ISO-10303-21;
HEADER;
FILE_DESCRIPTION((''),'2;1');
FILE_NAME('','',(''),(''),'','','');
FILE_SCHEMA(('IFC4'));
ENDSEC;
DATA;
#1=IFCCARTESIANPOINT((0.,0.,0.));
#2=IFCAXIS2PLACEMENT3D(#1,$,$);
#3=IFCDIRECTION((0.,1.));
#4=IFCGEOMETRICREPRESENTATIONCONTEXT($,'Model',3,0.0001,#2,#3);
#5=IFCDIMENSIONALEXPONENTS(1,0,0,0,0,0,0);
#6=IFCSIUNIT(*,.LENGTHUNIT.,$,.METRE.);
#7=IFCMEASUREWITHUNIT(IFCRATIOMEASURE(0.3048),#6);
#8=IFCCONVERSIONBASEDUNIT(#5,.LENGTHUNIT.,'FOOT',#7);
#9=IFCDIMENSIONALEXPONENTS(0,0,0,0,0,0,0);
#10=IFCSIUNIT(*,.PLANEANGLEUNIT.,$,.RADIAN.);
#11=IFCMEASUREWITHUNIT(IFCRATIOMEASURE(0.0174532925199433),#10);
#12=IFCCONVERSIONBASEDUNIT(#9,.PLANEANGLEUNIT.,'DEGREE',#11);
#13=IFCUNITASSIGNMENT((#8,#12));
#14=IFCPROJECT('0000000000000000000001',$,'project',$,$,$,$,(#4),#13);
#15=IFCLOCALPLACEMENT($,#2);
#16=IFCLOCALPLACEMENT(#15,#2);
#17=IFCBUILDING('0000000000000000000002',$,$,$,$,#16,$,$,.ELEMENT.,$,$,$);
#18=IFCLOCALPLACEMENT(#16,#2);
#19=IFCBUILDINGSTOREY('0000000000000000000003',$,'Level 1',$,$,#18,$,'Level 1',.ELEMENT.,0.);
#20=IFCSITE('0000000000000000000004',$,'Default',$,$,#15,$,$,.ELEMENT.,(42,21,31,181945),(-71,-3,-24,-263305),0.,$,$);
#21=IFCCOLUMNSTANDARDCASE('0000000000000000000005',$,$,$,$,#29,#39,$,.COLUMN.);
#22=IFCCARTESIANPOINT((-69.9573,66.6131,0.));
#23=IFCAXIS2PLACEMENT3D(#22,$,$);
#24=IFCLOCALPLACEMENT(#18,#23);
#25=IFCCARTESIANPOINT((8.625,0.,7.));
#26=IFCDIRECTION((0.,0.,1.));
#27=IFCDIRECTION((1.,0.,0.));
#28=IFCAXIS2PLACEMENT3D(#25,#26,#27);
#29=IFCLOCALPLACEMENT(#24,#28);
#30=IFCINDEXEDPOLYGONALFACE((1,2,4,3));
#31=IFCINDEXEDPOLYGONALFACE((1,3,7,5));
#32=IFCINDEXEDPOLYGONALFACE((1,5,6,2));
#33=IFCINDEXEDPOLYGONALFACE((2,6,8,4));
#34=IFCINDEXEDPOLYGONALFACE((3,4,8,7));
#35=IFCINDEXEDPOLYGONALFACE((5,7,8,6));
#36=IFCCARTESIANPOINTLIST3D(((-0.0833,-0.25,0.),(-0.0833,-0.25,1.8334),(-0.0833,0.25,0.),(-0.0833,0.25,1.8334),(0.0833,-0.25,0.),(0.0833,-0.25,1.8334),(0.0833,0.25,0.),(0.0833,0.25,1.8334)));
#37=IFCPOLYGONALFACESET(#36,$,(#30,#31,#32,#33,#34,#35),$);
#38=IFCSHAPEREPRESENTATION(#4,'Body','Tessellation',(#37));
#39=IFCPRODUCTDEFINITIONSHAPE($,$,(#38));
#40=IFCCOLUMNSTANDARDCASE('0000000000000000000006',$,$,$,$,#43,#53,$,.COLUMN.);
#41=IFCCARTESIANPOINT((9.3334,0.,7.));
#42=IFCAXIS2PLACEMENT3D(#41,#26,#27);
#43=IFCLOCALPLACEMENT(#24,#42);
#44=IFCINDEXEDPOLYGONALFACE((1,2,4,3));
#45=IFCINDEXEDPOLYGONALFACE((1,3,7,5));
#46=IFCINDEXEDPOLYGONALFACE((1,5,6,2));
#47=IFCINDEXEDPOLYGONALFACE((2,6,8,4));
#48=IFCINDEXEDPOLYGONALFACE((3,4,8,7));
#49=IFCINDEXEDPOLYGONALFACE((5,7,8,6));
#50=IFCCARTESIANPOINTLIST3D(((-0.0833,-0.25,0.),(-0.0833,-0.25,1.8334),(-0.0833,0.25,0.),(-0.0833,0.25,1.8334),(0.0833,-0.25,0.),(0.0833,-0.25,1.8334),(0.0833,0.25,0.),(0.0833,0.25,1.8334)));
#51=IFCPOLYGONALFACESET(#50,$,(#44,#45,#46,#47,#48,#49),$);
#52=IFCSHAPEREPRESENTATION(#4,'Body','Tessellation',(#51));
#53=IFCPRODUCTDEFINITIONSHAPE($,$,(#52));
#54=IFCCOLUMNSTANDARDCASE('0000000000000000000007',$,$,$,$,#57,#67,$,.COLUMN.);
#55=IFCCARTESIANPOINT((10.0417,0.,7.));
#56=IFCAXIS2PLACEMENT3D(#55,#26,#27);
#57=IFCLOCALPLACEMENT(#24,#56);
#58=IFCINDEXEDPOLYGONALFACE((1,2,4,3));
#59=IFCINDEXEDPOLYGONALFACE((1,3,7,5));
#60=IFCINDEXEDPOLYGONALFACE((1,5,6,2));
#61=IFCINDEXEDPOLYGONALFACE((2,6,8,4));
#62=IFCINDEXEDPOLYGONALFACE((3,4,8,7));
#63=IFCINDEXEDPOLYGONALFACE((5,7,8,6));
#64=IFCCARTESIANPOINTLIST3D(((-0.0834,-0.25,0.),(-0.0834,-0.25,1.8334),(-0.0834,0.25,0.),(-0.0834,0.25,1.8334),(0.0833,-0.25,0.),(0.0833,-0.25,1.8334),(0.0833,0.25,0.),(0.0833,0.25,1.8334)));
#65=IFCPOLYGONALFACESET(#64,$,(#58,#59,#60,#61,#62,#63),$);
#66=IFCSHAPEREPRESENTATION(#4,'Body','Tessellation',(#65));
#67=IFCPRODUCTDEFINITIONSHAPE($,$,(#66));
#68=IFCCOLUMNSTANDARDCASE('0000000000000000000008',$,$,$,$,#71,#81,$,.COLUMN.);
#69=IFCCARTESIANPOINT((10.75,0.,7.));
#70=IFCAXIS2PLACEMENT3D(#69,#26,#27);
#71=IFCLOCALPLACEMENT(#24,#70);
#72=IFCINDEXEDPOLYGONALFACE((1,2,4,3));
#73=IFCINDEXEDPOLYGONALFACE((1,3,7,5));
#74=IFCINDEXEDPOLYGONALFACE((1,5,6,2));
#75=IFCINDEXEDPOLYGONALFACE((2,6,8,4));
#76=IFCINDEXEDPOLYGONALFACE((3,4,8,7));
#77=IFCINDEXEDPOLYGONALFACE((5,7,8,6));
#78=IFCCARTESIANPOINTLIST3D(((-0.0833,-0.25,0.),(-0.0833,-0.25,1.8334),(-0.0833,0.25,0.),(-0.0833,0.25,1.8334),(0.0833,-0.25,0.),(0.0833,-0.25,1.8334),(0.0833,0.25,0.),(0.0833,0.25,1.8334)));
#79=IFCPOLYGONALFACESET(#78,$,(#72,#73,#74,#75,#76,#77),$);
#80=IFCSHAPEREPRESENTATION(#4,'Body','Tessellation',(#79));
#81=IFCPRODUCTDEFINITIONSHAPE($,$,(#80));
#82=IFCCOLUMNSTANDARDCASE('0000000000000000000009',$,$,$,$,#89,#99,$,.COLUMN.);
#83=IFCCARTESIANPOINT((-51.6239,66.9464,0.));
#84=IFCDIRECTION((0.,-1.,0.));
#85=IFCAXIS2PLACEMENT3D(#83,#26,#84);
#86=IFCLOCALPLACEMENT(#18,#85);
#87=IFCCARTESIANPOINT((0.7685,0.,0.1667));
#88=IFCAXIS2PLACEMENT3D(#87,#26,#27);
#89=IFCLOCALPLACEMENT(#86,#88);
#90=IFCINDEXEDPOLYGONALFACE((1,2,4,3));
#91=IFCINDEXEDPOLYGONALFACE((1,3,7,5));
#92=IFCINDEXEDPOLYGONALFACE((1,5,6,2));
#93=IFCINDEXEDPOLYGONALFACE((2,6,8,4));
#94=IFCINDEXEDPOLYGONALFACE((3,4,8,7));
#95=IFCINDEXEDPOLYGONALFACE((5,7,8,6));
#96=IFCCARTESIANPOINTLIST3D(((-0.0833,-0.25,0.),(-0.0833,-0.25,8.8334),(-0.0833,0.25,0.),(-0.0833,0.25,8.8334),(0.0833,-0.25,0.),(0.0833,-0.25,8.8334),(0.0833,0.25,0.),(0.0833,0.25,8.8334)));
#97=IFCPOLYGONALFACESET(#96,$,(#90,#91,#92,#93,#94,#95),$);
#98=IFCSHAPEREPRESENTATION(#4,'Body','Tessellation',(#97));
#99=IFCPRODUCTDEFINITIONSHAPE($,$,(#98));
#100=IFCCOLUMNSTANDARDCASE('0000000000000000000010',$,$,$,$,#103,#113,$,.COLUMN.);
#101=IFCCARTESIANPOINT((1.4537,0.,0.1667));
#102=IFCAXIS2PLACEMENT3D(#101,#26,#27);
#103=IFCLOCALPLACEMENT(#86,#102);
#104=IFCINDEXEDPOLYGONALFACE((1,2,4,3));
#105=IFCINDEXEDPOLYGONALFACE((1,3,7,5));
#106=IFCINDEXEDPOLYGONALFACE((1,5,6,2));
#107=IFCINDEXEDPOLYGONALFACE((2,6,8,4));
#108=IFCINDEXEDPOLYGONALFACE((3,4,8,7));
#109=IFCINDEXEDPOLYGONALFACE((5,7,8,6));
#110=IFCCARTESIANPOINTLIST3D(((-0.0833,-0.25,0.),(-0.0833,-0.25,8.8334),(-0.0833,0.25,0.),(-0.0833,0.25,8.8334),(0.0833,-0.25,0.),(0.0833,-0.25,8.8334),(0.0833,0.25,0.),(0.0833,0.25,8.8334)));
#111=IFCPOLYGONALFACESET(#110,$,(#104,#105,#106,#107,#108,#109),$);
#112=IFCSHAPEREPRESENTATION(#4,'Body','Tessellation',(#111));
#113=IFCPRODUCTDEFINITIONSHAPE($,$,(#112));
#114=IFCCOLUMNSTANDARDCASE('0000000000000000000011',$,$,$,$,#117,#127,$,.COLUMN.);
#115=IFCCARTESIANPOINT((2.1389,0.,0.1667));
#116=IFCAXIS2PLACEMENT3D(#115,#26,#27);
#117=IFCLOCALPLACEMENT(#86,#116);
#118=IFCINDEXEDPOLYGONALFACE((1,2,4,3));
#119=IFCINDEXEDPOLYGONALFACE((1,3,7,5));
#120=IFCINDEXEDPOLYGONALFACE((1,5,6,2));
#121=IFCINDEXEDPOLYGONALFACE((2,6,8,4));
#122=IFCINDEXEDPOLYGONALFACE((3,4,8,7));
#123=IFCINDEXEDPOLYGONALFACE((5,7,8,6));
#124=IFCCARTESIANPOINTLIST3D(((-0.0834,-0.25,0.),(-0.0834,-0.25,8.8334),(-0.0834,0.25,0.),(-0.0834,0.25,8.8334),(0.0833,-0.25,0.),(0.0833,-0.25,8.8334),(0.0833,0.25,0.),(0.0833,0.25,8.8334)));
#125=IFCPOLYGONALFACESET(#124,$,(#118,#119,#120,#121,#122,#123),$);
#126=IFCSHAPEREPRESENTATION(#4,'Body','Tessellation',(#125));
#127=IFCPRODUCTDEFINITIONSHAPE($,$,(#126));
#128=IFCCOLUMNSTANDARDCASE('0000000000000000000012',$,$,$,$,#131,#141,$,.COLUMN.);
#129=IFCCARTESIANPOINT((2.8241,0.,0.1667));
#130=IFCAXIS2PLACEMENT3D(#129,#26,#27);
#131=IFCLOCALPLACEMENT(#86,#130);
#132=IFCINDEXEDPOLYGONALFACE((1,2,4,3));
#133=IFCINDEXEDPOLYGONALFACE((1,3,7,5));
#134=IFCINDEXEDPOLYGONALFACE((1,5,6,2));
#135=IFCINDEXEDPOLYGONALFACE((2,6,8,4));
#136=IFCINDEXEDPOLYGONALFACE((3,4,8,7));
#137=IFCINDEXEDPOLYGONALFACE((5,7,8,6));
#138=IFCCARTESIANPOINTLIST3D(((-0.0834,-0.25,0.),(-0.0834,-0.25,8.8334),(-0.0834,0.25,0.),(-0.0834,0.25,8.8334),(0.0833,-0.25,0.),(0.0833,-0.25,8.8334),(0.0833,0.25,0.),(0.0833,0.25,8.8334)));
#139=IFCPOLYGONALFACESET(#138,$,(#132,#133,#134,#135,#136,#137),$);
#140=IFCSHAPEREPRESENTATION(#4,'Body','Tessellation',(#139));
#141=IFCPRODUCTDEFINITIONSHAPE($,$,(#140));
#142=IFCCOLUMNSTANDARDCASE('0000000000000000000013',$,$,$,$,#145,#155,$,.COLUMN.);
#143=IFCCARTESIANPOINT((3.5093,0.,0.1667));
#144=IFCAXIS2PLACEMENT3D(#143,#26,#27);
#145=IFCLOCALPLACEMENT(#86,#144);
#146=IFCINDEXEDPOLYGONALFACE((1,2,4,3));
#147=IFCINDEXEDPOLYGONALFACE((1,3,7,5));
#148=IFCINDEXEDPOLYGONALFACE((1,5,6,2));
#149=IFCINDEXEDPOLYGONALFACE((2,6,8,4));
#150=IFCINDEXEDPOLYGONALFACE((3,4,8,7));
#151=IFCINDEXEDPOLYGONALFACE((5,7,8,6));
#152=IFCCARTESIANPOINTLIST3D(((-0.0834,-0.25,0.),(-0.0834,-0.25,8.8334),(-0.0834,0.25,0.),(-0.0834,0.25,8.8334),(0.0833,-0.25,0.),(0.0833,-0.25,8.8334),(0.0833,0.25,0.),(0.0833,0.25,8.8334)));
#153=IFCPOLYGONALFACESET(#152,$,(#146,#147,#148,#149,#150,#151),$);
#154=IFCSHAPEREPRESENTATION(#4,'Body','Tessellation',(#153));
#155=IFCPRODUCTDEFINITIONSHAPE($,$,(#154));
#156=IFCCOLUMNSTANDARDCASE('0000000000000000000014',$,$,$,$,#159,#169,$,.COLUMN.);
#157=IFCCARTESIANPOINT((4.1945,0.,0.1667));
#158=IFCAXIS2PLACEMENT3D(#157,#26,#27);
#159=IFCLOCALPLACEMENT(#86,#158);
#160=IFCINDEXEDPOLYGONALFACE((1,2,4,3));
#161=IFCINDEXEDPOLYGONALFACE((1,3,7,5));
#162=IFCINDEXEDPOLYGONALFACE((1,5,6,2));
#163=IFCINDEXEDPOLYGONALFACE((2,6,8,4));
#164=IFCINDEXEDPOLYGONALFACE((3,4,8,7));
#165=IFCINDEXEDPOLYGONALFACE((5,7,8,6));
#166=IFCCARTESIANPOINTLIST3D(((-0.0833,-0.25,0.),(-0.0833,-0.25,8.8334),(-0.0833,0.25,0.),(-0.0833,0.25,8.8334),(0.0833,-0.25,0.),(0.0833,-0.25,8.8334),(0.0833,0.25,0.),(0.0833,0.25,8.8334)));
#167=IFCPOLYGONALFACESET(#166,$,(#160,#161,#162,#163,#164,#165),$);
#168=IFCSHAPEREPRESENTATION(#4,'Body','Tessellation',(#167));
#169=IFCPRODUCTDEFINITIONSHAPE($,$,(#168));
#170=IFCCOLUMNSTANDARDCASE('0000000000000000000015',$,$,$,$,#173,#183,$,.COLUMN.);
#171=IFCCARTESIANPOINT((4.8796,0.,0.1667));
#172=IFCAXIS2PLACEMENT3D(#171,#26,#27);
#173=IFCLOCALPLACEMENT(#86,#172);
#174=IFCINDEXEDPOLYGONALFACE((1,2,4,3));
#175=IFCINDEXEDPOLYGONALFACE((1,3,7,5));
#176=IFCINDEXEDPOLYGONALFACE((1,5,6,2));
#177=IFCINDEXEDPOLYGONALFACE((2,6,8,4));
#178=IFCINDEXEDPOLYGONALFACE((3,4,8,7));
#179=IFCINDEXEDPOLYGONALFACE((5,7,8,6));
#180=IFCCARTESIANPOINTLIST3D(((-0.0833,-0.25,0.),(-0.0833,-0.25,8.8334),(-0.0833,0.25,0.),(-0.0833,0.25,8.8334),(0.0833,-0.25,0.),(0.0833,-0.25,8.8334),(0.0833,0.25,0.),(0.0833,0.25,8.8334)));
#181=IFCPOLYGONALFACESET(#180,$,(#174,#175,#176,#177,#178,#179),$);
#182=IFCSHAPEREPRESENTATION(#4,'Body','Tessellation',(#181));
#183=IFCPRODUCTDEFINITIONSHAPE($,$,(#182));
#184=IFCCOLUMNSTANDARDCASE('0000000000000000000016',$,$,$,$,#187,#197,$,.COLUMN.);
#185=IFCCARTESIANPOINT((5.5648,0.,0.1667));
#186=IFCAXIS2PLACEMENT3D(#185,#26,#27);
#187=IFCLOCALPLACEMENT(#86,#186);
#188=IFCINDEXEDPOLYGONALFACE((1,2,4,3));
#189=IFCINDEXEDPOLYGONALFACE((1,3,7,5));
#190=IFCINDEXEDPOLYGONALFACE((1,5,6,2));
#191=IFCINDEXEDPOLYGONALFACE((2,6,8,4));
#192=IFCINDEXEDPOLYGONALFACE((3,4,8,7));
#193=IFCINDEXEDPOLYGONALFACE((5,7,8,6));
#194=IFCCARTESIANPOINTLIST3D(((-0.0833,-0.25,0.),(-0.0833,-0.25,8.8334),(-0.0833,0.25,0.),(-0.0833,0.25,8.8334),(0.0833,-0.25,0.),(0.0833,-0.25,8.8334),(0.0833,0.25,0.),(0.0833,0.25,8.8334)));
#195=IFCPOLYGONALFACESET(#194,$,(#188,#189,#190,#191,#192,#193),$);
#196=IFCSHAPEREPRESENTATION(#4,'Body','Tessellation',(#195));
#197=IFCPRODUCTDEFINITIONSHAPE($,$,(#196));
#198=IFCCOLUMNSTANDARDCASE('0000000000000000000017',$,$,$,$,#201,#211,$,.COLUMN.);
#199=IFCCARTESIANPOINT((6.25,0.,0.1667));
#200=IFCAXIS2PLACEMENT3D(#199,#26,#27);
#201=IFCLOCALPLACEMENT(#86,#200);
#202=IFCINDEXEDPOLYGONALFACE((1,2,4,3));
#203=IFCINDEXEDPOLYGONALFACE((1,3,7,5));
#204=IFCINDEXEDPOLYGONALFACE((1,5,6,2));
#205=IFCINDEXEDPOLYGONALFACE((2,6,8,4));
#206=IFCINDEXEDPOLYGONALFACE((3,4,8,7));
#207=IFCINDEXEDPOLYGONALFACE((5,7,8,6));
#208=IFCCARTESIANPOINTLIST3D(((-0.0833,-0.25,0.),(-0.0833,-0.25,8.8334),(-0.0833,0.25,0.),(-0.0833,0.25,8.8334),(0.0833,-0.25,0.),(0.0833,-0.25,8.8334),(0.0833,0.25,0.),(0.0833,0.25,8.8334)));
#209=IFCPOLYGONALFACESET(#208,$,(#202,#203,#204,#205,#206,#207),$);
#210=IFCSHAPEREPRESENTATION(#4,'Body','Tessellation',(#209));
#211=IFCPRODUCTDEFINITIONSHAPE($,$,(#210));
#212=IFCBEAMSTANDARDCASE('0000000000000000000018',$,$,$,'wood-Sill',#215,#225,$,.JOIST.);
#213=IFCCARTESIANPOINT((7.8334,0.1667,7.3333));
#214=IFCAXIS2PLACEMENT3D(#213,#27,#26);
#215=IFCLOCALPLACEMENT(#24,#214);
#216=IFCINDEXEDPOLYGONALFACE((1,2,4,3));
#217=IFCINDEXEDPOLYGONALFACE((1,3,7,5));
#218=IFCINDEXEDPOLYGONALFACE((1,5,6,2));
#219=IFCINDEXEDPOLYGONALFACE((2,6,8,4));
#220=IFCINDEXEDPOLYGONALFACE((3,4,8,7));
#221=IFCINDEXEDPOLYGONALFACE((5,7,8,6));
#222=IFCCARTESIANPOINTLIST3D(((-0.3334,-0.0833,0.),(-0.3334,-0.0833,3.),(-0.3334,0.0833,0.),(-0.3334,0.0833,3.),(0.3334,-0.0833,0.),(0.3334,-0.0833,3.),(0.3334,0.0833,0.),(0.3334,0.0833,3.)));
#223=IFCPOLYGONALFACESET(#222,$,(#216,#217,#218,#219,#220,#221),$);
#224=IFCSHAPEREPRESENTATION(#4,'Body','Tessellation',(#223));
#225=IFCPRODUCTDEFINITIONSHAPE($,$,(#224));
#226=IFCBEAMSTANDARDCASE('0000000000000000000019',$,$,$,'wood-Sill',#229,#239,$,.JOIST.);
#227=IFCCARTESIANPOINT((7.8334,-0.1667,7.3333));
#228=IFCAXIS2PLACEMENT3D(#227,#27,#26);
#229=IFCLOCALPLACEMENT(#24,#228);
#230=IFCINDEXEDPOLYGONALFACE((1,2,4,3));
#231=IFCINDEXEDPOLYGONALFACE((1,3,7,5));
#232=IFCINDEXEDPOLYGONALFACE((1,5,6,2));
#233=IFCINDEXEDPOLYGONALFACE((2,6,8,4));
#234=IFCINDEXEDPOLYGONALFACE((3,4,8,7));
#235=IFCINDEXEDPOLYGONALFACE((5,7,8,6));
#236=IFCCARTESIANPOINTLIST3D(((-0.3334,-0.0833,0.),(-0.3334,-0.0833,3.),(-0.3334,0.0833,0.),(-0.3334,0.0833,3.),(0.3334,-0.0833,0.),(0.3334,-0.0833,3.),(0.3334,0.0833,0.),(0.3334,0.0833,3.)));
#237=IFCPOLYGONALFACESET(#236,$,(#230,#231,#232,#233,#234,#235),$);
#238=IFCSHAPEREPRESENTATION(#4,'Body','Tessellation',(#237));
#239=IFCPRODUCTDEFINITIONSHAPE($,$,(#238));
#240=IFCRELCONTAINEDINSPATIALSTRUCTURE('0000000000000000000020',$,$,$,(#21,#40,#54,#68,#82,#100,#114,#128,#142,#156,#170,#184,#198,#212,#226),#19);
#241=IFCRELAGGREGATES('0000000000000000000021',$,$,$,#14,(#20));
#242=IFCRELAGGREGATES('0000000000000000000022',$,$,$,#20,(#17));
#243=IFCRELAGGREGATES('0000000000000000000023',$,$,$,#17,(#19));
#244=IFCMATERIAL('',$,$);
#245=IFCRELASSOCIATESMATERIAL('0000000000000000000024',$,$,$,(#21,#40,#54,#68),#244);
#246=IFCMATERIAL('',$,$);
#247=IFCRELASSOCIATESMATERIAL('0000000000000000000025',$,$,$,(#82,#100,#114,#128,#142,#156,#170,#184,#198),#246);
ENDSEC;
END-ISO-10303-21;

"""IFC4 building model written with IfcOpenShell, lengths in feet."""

from ifc_helpers import new_model, entity, si_unit, converted_unit, direction, frame, origin, origin_with_axes, place, context, project, spatial, rectangle, extrude, material, element, save


model = new_model("IFC4")

# Units and contexts
model_context = context("Model", 3, precision=0.0001, world=origin(), true_north=direction((0.0, 1.0)))
ifc_project = project(units=[converted_unit("LENGTHUNIT", "FOOT", entity("IfcRatioMeasure", 0.3048), si_unit("LENGTHUNIT", "METRE"), dimensions=[1, 0, 0, 0, 0, 0, 0]), converted_unit("PLANEANGLEUNIT", "DEGREE", entity("IfcRatioMeasure", 0.0174532925199433), si_unit("PLANEANGLEUNIT", "RADIAN"), dimensions=[0, 0, 0, 0, 0, 0, 0])], contexts=[model_context])

# Site, building, storey
site_placement = place(None, origin())
site = spatial("IfcSite", under=ifc_project, at=site_placement, Name="Default", CompositionType="ELEMENT", RefLatitude=(42, 21, 31, 181945), RefLongitude=(-71, -3, -24, -263305), RefElevation=0.0)
building_placement = place(site_placement, origin())
building = spatial("IfcBuilding", under=site, at=building_placement, CompositionType="ELEMENT")
storey_placement = place(building_placement, origin())
storey = spatial("IfcBuildingStorey", under=building, at=storey_placement, Name="Level 1", LongName="Level 1", CompositionType="ELEMENT", Elevation=0.0)

# Columns
ifc_material_1 = material(Name="")
placement_1 = place(storey_placement, frame((-69.9573, 66.6131, 0.0)))
ifc_material_2 = material(Name="")
for number, where, z_axis, x_axis in (
    (1, (8.625, 0.0, 7.0), (0.0, 0.0, 1.0), (1.0, 0.0, 0.0)),
    (2, (9.3334, 0.0, 7.0), (0.0, 0.0, 1.0), (1.0, 0.0, 0.0)),
    (3, (10.0417, 0.0, 7.0), (0.0, 0.0, 1.0), (1.0, 0.0, 0.0)),
    (4, (10.75, 0.0, 7.0), (0.0, 0.0, 1.0), (1.0, 0.0, 0.0)),
):
    element("IfcColumnStandardCase", number, at=place(placement_1, frame(where, z_axis=z_axis, x_axis=x_axis)), inside=storey, material=ifc_material_2, PredefinedType="COLUMN", context=model_context, shape_type="SweptSolid", body=[
        extrude(rectangle(XDim=0.1667, YDim=0.5), origin(), (0.0, 0.0, 1.0), 1.8334),
    ])
placement_2 = place(storey_placement, frame((-51.6239, 66.9464, 0.0), z_axis=(0.0, 0.0, 1.0), x_axis=(0.0, -1.0, 0.0)))
for number, where, z_axis, x_axis in (
    (5, (0.7685, 0.0, 0.1667), (0.0, 0.0, 1.0), (1.0, 0.0, 0.0)),
    (6, (1.4537, 0.0, 0.1667), (0.0, 0.0, 1.0), (1.0, 0.0, 0.0)),
    (7, (2.1389, 0.0, 0.1667), (0.0, 0.0, 1.0), (1.0, 0.0, 0.0)),
    (8, (2.8241, 0.0, 0.1667), (0.0, 0.0, 1.0), (1.0, 0.0, 0.0)),
    (9, (3.5093, 0.0, 0.1667), (0.0, 0.0, 1.0), (1.0, 0.0, 0.0)),
    (10, (4.1945, 0.0, 0.1667), (0.0, 0.0, 1.0), (1.0, 0.0, 0.0)),
    (11, (4.8796, 0.0, 0.1667), (0.0, 0.0, 1.0), (1.0, 0.0, 0.0)),
    (12, (5.5648, 0.0, 0.1667), (0.0, 0.0, 1.0), (1.0, 0.0, 0.0)),
    (13, (6.25, 0.0, 0.1667), (0.0, 0.0, 1.0), (1.0, 0.0, 0.0)),
):
    element("IfcColumnStandardCase", number, at=place(placement_2, frame(where, z_axis=z_axis, x_axis=x_axis)), inside=storey, material=ifc_material_1, PredefinedType="COLUMN", context=model_context, shape_type="SweptSolid", body=[
        extrude(rectangle(XDim=0.1667, YDim=0.5), origin(), (0.0, 0.0, 1.0), 8.8334),
    ])

# Beams
for number, where, z_axis, x_axis in (
    (14, (7.8334, 0.1667, 7.3333), (1.0, 0.0, 0.0), (0.0, 0.0, 1.0)),
    (15, (7.8334, -0.1667, 7.3333), (1.0, 0.0, 0.0), (0.0, 0.0, 1.0)),
):
    element("IfcBeamStandardCase", number, at=place(placement_1, frame(where, z_axis=z_axis, x_axis=x_axis)), inside=storey, ObjectType="wood-Sill", PredefinedType="JOIST", context=model_context, shape_type="SweptSolid", body=[
        extrude(rectangle(XDim=0.6667, YDim=0.1667), origin_with_axes(), (0.0, 0.0, 1.0), 3.0),
    ])

save(model, "model.ifc")
